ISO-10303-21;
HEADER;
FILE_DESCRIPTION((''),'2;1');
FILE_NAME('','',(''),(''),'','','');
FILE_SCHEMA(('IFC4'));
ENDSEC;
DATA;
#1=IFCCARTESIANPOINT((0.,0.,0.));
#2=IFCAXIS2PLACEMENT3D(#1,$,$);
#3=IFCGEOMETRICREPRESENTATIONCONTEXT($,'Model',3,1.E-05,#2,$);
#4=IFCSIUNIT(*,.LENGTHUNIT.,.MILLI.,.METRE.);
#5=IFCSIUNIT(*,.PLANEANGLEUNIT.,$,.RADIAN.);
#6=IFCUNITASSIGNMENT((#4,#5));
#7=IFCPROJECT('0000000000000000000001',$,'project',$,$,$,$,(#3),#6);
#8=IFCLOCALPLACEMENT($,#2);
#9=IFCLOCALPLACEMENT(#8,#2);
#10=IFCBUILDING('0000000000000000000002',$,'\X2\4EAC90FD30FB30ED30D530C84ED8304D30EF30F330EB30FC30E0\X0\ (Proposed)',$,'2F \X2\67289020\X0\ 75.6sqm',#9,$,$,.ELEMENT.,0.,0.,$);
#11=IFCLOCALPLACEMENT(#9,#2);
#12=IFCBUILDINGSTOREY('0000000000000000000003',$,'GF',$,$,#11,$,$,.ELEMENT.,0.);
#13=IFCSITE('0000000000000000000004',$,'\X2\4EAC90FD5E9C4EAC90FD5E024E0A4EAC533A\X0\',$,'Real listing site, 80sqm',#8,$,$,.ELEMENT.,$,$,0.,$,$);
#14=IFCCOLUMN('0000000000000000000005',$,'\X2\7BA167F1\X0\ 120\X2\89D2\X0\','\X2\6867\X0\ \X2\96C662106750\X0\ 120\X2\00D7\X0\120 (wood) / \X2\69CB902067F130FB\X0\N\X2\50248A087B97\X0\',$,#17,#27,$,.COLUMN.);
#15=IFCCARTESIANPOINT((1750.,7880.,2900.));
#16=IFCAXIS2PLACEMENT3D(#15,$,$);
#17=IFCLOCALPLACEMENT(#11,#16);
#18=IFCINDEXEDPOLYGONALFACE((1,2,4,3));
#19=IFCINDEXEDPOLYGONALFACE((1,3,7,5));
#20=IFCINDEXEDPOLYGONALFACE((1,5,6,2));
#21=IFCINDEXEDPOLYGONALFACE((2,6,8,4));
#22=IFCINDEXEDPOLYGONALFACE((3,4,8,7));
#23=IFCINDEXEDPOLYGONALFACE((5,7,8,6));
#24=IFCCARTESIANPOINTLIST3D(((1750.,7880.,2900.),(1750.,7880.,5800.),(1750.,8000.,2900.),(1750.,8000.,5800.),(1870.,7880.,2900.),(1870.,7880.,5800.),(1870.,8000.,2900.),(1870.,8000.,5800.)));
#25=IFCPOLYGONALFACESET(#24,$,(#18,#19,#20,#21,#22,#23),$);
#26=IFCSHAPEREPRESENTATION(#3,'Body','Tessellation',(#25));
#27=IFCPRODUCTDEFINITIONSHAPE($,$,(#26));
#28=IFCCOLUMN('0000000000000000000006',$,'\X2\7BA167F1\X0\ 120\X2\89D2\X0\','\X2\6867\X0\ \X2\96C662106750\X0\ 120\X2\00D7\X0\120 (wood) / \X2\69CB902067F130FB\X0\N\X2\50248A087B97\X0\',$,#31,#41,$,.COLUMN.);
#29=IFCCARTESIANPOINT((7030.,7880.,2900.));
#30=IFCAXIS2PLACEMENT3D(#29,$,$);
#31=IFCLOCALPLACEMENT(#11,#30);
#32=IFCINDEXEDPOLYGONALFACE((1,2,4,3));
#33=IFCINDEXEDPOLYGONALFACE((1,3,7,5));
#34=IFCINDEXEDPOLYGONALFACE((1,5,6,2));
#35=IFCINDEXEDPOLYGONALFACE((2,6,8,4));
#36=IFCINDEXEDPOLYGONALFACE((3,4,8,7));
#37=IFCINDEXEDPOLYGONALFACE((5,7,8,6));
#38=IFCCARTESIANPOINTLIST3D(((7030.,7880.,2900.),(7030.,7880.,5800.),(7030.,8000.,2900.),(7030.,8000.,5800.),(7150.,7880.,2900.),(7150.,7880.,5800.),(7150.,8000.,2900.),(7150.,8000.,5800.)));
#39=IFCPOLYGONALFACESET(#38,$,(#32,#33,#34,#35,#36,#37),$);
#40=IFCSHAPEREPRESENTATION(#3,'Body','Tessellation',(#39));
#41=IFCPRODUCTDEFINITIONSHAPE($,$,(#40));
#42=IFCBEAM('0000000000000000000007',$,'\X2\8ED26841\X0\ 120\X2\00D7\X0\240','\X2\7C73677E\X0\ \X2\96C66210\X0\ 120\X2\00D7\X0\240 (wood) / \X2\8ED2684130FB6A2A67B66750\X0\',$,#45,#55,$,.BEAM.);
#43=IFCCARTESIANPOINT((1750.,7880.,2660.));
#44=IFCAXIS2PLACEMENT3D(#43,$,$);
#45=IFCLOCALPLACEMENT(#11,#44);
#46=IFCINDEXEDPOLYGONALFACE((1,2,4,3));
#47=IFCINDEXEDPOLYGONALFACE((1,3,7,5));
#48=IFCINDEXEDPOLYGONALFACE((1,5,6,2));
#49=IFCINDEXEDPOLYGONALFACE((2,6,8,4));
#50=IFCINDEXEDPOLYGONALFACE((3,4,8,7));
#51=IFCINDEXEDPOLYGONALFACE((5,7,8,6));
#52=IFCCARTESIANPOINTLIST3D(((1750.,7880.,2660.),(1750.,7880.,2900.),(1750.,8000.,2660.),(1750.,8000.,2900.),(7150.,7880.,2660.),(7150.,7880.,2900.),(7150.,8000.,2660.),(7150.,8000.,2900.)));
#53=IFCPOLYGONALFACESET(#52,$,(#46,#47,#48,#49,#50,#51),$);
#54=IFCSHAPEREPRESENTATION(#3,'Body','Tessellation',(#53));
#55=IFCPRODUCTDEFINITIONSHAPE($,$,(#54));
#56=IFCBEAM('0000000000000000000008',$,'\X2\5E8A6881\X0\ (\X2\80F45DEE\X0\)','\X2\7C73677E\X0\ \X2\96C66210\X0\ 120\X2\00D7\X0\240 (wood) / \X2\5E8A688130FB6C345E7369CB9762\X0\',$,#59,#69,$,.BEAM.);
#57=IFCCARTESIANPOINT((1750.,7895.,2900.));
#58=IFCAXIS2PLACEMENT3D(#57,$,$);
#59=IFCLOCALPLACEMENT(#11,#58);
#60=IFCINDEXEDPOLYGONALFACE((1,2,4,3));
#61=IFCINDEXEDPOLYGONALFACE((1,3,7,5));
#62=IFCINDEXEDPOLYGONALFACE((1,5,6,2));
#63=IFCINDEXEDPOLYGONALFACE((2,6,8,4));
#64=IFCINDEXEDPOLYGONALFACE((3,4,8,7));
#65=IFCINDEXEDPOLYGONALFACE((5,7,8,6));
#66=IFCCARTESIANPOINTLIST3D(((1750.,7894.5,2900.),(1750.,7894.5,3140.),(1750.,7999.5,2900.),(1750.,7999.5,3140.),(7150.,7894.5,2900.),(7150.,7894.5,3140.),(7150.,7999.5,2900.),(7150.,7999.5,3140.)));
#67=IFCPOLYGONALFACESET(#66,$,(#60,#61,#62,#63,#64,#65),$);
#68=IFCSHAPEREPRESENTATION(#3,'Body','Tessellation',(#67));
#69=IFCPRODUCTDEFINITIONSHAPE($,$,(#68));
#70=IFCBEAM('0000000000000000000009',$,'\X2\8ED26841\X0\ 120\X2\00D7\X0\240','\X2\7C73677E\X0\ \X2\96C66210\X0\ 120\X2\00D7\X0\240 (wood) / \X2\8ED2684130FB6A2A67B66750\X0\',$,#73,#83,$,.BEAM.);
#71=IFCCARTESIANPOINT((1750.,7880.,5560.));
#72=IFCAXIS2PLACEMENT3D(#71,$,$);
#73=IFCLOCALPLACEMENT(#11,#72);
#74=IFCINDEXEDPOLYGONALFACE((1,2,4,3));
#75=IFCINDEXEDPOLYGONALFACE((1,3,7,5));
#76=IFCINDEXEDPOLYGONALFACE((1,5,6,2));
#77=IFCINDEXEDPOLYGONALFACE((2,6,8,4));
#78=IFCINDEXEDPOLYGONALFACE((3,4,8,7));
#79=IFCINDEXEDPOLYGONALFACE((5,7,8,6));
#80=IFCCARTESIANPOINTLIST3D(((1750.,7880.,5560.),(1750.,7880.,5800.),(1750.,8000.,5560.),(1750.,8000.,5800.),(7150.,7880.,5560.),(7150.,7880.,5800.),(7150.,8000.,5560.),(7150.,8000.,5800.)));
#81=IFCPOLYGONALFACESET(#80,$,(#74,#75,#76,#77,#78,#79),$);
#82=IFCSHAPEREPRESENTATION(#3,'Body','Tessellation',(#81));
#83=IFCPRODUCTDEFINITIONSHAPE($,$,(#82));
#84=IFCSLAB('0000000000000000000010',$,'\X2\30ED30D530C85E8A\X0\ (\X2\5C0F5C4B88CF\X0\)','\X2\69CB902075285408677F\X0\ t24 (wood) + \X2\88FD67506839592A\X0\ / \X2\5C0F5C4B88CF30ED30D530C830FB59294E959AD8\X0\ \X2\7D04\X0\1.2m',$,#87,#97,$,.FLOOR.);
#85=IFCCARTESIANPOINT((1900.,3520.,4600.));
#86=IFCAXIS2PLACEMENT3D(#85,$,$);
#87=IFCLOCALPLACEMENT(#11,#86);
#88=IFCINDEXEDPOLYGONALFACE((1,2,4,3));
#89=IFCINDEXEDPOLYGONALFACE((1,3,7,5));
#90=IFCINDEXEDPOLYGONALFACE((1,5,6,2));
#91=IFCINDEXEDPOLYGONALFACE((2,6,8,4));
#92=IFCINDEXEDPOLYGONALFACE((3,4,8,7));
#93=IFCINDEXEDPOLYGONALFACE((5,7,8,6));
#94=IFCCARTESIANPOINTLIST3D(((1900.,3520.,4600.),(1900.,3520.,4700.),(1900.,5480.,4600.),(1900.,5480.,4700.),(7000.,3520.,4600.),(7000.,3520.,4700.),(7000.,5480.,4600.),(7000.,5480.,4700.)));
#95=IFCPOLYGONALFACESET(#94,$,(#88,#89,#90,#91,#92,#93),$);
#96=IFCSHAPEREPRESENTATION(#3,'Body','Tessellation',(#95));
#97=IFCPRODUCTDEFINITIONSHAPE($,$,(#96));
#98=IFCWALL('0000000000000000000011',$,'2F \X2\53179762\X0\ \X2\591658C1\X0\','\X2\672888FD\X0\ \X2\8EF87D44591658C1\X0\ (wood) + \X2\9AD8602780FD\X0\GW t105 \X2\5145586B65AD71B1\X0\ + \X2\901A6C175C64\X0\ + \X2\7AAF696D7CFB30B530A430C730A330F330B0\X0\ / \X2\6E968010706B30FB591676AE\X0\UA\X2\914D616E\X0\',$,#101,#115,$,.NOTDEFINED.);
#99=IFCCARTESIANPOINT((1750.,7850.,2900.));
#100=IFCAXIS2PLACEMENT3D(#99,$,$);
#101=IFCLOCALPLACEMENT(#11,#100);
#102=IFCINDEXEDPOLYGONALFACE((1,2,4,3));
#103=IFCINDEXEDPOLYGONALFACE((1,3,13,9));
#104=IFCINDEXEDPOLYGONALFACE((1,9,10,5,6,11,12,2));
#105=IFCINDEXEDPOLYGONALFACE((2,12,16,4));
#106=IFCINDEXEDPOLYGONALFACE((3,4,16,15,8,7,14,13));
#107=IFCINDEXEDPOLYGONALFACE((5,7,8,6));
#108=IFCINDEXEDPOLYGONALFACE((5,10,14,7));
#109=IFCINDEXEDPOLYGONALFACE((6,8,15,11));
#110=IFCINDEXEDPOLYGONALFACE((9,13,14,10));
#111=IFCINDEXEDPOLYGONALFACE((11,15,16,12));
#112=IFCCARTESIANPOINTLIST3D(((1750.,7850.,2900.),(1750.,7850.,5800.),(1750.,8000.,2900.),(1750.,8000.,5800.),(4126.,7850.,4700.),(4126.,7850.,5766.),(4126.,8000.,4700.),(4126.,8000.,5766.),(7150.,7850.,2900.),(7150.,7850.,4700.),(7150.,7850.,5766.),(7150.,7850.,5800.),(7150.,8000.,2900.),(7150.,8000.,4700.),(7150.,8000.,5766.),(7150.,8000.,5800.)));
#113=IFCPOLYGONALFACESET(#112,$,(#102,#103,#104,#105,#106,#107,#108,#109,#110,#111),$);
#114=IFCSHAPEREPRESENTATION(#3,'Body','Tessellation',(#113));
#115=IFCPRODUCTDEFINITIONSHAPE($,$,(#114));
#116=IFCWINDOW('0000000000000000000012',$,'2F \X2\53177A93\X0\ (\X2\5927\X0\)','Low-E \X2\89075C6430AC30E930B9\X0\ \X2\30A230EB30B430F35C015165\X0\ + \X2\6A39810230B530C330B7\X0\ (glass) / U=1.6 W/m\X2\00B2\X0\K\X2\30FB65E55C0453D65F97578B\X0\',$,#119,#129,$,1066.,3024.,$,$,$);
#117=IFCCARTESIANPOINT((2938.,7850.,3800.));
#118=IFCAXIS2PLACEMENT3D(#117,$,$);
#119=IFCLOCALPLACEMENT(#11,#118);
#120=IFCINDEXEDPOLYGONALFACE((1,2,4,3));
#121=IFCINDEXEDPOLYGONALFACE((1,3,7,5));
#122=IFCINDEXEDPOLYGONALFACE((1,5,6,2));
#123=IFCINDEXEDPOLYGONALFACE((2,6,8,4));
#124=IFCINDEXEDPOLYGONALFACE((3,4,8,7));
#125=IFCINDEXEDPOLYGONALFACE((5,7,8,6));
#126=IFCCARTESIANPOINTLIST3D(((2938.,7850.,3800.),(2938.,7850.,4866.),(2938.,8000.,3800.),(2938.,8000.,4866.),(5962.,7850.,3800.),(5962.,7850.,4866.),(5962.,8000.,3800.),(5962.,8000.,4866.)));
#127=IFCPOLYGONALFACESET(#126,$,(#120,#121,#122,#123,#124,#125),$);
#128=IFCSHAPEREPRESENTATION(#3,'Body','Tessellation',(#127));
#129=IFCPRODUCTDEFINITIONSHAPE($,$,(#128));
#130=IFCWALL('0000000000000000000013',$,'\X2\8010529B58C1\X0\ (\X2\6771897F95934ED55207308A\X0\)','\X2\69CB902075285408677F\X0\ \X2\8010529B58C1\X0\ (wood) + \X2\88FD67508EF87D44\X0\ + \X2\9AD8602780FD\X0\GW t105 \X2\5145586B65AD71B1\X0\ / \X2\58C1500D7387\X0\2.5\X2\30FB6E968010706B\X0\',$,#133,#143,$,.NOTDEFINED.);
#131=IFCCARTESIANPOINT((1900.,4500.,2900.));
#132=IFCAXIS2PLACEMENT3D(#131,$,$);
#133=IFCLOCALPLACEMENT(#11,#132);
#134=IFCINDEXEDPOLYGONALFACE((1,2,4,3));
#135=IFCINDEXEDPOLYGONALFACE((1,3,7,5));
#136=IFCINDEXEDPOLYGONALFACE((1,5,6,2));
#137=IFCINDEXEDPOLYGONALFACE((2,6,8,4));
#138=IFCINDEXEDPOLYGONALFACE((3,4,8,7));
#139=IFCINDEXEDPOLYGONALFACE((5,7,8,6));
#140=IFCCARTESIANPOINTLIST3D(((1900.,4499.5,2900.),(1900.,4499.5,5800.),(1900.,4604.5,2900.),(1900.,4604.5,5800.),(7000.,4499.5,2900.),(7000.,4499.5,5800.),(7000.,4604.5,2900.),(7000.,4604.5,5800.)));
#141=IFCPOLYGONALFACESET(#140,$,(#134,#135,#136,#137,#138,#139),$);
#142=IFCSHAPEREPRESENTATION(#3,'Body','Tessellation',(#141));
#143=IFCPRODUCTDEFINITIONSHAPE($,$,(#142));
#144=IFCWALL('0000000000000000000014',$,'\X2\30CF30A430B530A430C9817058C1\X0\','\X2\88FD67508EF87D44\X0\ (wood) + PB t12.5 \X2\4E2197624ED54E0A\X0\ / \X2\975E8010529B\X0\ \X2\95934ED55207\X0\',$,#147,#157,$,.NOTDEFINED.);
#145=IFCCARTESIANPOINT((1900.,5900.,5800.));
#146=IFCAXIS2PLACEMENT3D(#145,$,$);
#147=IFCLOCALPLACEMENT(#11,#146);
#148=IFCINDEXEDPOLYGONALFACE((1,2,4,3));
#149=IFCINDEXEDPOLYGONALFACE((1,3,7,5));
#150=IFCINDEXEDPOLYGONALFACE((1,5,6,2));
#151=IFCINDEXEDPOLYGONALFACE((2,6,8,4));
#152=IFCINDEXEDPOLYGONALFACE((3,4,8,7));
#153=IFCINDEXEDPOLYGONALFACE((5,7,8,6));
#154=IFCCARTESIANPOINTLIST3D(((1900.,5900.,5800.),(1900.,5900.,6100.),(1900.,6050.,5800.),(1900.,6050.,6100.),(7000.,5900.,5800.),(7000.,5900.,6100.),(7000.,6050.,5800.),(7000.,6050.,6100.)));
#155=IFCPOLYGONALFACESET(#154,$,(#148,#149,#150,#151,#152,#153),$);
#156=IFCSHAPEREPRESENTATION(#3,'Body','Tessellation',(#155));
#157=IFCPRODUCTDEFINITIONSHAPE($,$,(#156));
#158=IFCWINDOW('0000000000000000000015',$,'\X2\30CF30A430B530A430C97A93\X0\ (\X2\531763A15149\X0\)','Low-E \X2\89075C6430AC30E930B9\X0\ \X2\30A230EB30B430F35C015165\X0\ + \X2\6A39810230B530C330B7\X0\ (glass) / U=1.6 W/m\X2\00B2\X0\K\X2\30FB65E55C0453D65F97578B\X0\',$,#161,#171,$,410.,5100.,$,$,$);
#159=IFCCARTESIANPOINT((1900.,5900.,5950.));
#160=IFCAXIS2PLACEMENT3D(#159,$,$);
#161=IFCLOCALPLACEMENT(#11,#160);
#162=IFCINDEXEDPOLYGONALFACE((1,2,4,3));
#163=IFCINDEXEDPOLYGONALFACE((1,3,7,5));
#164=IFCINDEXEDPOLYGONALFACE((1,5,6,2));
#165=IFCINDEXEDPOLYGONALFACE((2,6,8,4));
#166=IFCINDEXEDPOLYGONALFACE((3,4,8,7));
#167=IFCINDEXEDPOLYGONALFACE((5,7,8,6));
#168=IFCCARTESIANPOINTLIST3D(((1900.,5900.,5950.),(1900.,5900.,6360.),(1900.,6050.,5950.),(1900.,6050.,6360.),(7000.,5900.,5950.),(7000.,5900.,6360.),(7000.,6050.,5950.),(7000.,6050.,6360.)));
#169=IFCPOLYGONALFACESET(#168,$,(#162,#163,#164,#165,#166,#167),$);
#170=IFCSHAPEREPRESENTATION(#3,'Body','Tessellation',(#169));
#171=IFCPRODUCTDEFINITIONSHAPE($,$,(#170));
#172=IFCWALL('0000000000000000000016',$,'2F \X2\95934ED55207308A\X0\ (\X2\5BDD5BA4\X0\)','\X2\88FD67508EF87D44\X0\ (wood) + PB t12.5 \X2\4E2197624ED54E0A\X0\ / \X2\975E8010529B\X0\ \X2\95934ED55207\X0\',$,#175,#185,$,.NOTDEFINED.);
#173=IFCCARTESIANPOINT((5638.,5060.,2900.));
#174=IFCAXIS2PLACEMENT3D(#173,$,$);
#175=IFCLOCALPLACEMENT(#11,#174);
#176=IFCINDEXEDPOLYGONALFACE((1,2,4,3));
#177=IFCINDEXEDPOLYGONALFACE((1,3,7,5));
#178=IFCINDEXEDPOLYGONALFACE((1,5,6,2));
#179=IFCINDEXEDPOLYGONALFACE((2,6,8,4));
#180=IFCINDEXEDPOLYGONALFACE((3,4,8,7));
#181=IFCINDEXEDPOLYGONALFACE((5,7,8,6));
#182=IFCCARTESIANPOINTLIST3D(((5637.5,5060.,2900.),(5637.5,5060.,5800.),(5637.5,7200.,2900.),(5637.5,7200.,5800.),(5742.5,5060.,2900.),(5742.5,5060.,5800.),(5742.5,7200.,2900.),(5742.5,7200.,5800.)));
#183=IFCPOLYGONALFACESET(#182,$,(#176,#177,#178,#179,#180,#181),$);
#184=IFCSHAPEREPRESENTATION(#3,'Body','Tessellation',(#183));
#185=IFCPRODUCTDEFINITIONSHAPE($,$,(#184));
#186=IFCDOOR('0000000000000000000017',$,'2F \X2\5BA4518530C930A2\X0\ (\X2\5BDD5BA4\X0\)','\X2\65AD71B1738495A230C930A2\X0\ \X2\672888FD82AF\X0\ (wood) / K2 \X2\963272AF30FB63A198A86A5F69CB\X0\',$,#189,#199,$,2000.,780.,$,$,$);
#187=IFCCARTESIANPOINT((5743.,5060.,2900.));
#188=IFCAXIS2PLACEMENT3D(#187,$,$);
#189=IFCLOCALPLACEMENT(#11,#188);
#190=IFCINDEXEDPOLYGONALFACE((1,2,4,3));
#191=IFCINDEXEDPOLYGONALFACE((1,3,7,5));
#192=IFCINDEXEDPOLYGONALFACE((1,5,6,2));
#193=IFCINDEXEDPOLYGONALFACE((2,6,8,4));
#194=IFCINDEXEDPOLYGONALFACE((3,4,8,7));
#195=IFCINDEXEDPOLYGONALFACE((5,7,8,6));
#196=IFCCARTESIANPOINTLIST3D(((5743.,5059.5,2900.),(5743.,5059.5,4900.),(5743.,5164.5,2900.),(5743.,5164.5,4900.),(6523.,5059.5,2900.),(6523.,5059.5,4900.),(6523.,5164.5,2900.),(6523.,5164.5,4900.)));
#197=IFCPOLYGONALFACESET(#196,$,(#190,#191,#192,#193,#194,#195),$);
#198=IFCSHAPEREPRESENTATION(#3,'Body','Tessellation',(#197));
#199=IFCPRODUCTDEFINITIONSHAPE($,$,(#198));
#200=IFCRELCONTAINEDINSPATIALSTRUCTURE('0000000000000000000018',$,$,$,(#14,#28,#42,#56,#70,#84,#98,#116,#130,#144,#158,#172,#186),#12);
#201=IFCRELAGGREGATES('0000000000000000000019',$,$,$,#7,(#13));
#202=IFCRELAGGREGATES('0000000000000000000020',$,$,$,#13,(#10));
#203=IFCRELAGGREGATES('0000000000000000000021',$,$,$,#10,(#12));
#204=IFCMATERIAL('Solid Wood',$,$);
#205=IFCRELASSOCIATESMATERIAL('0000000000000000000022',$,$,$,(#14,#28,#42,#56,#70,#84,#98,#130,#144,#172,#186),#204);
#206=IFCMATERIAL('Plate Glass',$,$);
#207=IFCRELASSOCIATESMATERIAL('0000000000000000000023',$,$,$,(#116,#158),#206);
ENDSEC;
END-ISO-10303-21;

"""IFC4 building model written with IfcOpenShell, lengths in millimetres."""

from ifc_helpers import new_model, si_unit, frame, frame_2d, origin, place, context, project, spatial, rectangle, extrude, material, element, fill, save


model = new_model("IFC4")

# Units and contexts
model_context = context("Model", 3, precision=1e-05, world=origin())
ifc_project = project(units=[si_unit("LENGTHUNIT", "METRE", prefix="MILLI"), si_unit("PLANEANGLEUNIT", "RADIAN")], contexts=[model_context])

# Site, building, storey
site_placement = place(None, origin())
site = spatial("IfcSite", under=ifc_project, at=site_placement, Name="京都府京都市上京区", ObjectType="Real listing site, 80sqm", CompositionType="ELEMENT", RefElevation=0.0)
building_placement = place(site_placement, origin())
building = spatial("IfcBuilding", under=site, at=building_placement, Name="京都・ロフト付きワンルーム (Proposed)", ObjectType="2F 木造 75.6sqm", CompositionType="ELEMENT", ElevationOfRefHeight=0.0, ElevationOfTerrain=0.0)
storey_placement = place(building_placement, origin())
storey = spatial("IfcBuildingStorey", under=building, at=storey_placement, Name="GF", CompositionType="ELEMENT", Elevation=0.0)

# Columns
ifc_material_1 = material(Name="Solid Wood")
column_1_placement = place(storey_placement, frame((1750.0, 7880.0, 2900.0)))
element("IfcColumn", 1, at=column_1_placement, inside=storey, material=ifc_material_1, Name="管柱 120角", Description="桧 集成材 120×120 (wood) / 構造柱・N値計算", PredefinedType="COLUMN", context=model_context, shape_type="SweptSolid", body=[
    extrude(rectangle(XDim=120.0, YDim=120.0, at=frame_2d((60.0, 60.0))), frame((1750.0, 7880.0, 2900.0)), (0.0, 0.0, 1.0), 2900.0),
])
column_2_placement = place(storey_placement, frame((7030.0, 7880.0, 2900.0)))
element("IfcColumn", 2, at=column_2_placement, inside=storey, material=ifc_material_1, Name="管柱 120角", Description="桧 集成材 120×120 (wood) / 構造柱・N値計算", PredefinedType="COLUMN", context=model_context, shape_type="SweptSolid", body=[
    extrude(rectangle(XDim=120.0, YDim=120.0, at=frame_2d((60.0, 60.0))), frame((7030.0, 7880.0, 2900.0)), (0.0, 0.0, 1.0), 2900.0),
])

# Beams
beam_1_placement = place(storey_placement, frame((1750.0, 7880.0, 2660.0)))
element("IfcBeam", 3, at=beam_1_placement, inside=storey, material=ifc_material_1, Name="軒桁 120×240", Description="米松 集成 120×240 (wood) / 軒桁・横架材", PredefinedType="BEAM", context=model_context, shape_type="SweptSolid", body=[
    extrude(rectangle(XDim=5400.0, YDim=120.0, at=frame_2d((2700.0, 60.0))), frame((1750.0, 7880.0, 2660.0)), (0.0, 0.0, 1.0), 240.0),
])
beam_2_placement = place(storey_placement, frame((1750.0, 7895.0, 2900.0)))
element("IfcBeam", 4, at=beam_2_placement, inside=storey, material=ifc_material_1, Name="床梁 (胴差)", Description="米松 集成 120×240 (wood) / 床梁・水平構面", PredefinedType="BEAM", context=model_context, shape_type="SweptSolid", body=[
    extrude(rectangle(XDim=5400.0, YDim=105.0, at=frame_2d((2700.0, 52.0))), frame((1750.0, 7895.0, 2900.0)), (0.0, 0.0, 1.0), 240.0),
])
beam_3_placement = place(storey_placement, frame((1750.0, 7880.0, 5560.0)))
element("IfcBeam", 5, at=beam_3_placement, inside=storey, material=ifc_material_1, Name="軒桁 120×240", Description="米松 集成 120×240 (wood) / 軒桁・横架材", PredefinedType="BEAM", context=model_context, shape_type="SweptSolid", body=[
    extrude(rectangle(XDim=5400.0, YDim=120.0, at=frame_2d((2700.0, 60.0))), frame((1750.0, 7880.0, 5560.0)), (0.0, 0.0, 1.0), 240.0),
])

# Slab
slab_placement = place(storey_placement, frame((1900.0, 3520.0, 4600.0)))
element("IfcSlab", 6, at=slab_placement, inside=storey, material=ifc_material_1, Name="ロフト床 (小屋裏)", Description="構造用合板 t24 (wood) + 製材根太 / 小屋裏ロフト・天井高 約1.2m", PredefinedType="FLOOR", context=model_context, shape_type="SweptSolid", body=[
    extrude(rectangle(XDim=5100.0, YDim=1960.0, at=frame_2d((2550.0, 980.0))), frame((1900.0, 3520.0, 4600.0)), (0.0, 0.0, 1.0), 100.0),
])

# Wall, opening, window
wall_1_placement = place(storey_placement, frame((1750.0, 7850.0, 2900.0)))
wall_1 = element("IfcWall", 7, at=wall_1_placement, inside=storey, material=ifc_material_1, Name="2F 北面 外壁", Description="木製 軸組外壁 (wood) + 高性能GW t105 充填断熱 + 通気層 + 窯業系サイディング / 準耐火・外皮UA配慮", PredefinedType="NOTDEFINED", context=model_context, shape_type="SweptSolid", body=[
    extrude(rectangle(XDim=5400.0, YDim=150.0, at=frame_2d((2700.0, 75.0))), frame((1750.0, 7850.0, 2900.0)), (0.0, 0.0, 1.0), 2900.0),
])
opening_1_placement = place(storey_placement, frame((2938.0, 7850.0, 3800.0)))
opening_1 = element("IfcOpeningElement", 8, at=opening_1_placement, cuts=wall_1, PredefinedType="NOTDEFINED", context=model_context, shape_type="SweptSolid", body=[
    extrude(rectangle(XDim=3024.0, YDim=150.0, at=frame_2d((1512.0, 75.0))), frame((2938.0, 7850.0, 3800.0)), (0.0, 0.0, 1.0), 1066.0),
])
ifc_material_2 = material(Name="Plate Glass")
window_1_placement = place(storey_placement, frame((2938.0, 7850.0, 3800.0)))
window_1 = element("IfcWindow", 9, at=window_1_placement, inside=storey, material=ifc_material_2, Name="2F 北窓 (大)", Description="Low-E 複層ガラス アルゴン封入 + 樹脂サッシ (glass) / U=1.6 W/m²K・日射取得型", OverallHeight=1066.0, OverallWidth=3024.0, context=model_context, shape_type="SweptSolid", body=[
    extrude(rectangle(XDim=3024.0, YDim=150.0, at=frame_2d((1512.0, 75.0))), frame((2938.0, 7850.0, 3800.0)), (0.0, 0.0, 1.0), 1066.0),
])
fill(opening_1, window_1)

# Wall
wall_2_placement = place(storey_placement, frame((1900.0, 4500.0, 2900.0)))
element("IfcWall", 10, at=wall_2_placement, inside=storey, material=ifc_material_1, Name="耐力壁 (東西間仕切り)", Description="構造用合板 耐力壁 (wood) + 製材軸組 + 高性能GW t105 充填断熱 / 壁倍率2.5・準耐火", PredefinedType="NOTDEFINED", context=model_context, shape_type="SweptSolid", body=[
    extrude(rectangle(XDim=5100.0, YDim=105.0, at=frame_2d((2550.0, 52.0))), frame((1900.0, 4500.0, 2900.0)), (0.0, 0.0, 1.0), 2900.0),
])

# Wall, opening, window
wall_3_placement = place(storey_placement, frame((1900.0, 5900.0, 5800.0)))
wall_3 = element("IfcWall", 11, at=wall_3_placement, inside=storey, material=ifc_material_1, Name="ハイサイド腰壁", Description="製材軸組 (wood) + PB t12.5 両面仕上 / 非耐力 間仕切", PredefinedType="NOTDEFINED", context=model_context, shape_type="SweptSolid", body=[
    extrude(rectangle(XDim=5100.0, YDim=150.0, at=frame_2d((2550.0, 75.0))), frame((1900.0, 5900.0, 5800.0)), (0.0, 0.0, 1.0), 700.0),
])
opening_2_placement = place(storey_placement, frame((1900.0, 5900.0, 5950.0)))
opening_2 = element("IfcOpeningElement", 12, at=opening_2_placement, cuts=wall_3, PredefinedType="NOTDEFINED", context=model_context, shape_type="SweptSolid", body=[
    extrude(rectangle(XDim=5100.0, YDim=150.0, at=frame_2d((2550.0, 75.0))), frame((1900.0, 5900.0, 5950.0)), (0.0, 0.0, 1.0), 410.0),
])
window_2_placement = place(storey_placement, frame((1900.0, 5900.0, 5950.0)))
window_2 = element("IfcWindow", 13, at=window_2_placement, inside=storey, material=ifc_material_2, Name="ハイサイド窓 (北採光)", Description="Low-E 複層ガラス アルゴン封入 + 樹脂サッシ (glass) / U=1.6 W/m²K・日射取得型", OverallHeight=410.0, OverallWidth=5100.0, context=model_context, shape_type="SweptSolid", body=[
    extrude(rectangle(XDim=5100.0, YDim=150.0, at=frame_2d((2550.0, 75.0))), frame((1900.0, 5900.0, 5950.0)), (0.0, 0.0, 1.0), 410.0),
])
fill(opening_2, window_2)

# Wall
wall_4_placement = place(storey_placement, frame((5638.0, 5060.0, 2900.0)))
element("IfcWall", 14, at=wall_4_placement, inside=storey, material=ifc_material_1, Name="2F 間仕切り (寝室)", Description="製材軸組 (wood) + PB t12.5 両面仕上 / 非耐力 間仕切", PredefinedType="NOTDEFINED", context=model_context, shape_type="SweptSolid", body=[
    extrude(rectangle(XDim=105.0, YDim=2140.0, at=frame_2d((52.0, 1070.0))), frame((5638.0, 5060.0, 2900.0)), (0.0, 0.0, 1.0), 2900.0),
])

# Door
door_placement = place(storey_placement, frame((5743.0, 5060.0, 2900.0)))
element("IfcDoor", 15, at=door_placement, inside=storey, material=ifc_material_1, Name="2F 室内ドア (寝室)", Description="断熱玄関ドア 木製芯 (wood) / K2 防犯・採風機構", OverallHeight=2000.0, OverallWidth=780.0, context=model_context, shape_type="SweptSolid", body=[
    extrude(rectangle(XDim=780.0, YDim=105.0, at=frame_2d((390.0, 52.0))), frame((5743.0, 5060.0, 2900.0)), (0.0, 0.0, 1.0), 2000.0),
])

save(model, "model.ifc")
